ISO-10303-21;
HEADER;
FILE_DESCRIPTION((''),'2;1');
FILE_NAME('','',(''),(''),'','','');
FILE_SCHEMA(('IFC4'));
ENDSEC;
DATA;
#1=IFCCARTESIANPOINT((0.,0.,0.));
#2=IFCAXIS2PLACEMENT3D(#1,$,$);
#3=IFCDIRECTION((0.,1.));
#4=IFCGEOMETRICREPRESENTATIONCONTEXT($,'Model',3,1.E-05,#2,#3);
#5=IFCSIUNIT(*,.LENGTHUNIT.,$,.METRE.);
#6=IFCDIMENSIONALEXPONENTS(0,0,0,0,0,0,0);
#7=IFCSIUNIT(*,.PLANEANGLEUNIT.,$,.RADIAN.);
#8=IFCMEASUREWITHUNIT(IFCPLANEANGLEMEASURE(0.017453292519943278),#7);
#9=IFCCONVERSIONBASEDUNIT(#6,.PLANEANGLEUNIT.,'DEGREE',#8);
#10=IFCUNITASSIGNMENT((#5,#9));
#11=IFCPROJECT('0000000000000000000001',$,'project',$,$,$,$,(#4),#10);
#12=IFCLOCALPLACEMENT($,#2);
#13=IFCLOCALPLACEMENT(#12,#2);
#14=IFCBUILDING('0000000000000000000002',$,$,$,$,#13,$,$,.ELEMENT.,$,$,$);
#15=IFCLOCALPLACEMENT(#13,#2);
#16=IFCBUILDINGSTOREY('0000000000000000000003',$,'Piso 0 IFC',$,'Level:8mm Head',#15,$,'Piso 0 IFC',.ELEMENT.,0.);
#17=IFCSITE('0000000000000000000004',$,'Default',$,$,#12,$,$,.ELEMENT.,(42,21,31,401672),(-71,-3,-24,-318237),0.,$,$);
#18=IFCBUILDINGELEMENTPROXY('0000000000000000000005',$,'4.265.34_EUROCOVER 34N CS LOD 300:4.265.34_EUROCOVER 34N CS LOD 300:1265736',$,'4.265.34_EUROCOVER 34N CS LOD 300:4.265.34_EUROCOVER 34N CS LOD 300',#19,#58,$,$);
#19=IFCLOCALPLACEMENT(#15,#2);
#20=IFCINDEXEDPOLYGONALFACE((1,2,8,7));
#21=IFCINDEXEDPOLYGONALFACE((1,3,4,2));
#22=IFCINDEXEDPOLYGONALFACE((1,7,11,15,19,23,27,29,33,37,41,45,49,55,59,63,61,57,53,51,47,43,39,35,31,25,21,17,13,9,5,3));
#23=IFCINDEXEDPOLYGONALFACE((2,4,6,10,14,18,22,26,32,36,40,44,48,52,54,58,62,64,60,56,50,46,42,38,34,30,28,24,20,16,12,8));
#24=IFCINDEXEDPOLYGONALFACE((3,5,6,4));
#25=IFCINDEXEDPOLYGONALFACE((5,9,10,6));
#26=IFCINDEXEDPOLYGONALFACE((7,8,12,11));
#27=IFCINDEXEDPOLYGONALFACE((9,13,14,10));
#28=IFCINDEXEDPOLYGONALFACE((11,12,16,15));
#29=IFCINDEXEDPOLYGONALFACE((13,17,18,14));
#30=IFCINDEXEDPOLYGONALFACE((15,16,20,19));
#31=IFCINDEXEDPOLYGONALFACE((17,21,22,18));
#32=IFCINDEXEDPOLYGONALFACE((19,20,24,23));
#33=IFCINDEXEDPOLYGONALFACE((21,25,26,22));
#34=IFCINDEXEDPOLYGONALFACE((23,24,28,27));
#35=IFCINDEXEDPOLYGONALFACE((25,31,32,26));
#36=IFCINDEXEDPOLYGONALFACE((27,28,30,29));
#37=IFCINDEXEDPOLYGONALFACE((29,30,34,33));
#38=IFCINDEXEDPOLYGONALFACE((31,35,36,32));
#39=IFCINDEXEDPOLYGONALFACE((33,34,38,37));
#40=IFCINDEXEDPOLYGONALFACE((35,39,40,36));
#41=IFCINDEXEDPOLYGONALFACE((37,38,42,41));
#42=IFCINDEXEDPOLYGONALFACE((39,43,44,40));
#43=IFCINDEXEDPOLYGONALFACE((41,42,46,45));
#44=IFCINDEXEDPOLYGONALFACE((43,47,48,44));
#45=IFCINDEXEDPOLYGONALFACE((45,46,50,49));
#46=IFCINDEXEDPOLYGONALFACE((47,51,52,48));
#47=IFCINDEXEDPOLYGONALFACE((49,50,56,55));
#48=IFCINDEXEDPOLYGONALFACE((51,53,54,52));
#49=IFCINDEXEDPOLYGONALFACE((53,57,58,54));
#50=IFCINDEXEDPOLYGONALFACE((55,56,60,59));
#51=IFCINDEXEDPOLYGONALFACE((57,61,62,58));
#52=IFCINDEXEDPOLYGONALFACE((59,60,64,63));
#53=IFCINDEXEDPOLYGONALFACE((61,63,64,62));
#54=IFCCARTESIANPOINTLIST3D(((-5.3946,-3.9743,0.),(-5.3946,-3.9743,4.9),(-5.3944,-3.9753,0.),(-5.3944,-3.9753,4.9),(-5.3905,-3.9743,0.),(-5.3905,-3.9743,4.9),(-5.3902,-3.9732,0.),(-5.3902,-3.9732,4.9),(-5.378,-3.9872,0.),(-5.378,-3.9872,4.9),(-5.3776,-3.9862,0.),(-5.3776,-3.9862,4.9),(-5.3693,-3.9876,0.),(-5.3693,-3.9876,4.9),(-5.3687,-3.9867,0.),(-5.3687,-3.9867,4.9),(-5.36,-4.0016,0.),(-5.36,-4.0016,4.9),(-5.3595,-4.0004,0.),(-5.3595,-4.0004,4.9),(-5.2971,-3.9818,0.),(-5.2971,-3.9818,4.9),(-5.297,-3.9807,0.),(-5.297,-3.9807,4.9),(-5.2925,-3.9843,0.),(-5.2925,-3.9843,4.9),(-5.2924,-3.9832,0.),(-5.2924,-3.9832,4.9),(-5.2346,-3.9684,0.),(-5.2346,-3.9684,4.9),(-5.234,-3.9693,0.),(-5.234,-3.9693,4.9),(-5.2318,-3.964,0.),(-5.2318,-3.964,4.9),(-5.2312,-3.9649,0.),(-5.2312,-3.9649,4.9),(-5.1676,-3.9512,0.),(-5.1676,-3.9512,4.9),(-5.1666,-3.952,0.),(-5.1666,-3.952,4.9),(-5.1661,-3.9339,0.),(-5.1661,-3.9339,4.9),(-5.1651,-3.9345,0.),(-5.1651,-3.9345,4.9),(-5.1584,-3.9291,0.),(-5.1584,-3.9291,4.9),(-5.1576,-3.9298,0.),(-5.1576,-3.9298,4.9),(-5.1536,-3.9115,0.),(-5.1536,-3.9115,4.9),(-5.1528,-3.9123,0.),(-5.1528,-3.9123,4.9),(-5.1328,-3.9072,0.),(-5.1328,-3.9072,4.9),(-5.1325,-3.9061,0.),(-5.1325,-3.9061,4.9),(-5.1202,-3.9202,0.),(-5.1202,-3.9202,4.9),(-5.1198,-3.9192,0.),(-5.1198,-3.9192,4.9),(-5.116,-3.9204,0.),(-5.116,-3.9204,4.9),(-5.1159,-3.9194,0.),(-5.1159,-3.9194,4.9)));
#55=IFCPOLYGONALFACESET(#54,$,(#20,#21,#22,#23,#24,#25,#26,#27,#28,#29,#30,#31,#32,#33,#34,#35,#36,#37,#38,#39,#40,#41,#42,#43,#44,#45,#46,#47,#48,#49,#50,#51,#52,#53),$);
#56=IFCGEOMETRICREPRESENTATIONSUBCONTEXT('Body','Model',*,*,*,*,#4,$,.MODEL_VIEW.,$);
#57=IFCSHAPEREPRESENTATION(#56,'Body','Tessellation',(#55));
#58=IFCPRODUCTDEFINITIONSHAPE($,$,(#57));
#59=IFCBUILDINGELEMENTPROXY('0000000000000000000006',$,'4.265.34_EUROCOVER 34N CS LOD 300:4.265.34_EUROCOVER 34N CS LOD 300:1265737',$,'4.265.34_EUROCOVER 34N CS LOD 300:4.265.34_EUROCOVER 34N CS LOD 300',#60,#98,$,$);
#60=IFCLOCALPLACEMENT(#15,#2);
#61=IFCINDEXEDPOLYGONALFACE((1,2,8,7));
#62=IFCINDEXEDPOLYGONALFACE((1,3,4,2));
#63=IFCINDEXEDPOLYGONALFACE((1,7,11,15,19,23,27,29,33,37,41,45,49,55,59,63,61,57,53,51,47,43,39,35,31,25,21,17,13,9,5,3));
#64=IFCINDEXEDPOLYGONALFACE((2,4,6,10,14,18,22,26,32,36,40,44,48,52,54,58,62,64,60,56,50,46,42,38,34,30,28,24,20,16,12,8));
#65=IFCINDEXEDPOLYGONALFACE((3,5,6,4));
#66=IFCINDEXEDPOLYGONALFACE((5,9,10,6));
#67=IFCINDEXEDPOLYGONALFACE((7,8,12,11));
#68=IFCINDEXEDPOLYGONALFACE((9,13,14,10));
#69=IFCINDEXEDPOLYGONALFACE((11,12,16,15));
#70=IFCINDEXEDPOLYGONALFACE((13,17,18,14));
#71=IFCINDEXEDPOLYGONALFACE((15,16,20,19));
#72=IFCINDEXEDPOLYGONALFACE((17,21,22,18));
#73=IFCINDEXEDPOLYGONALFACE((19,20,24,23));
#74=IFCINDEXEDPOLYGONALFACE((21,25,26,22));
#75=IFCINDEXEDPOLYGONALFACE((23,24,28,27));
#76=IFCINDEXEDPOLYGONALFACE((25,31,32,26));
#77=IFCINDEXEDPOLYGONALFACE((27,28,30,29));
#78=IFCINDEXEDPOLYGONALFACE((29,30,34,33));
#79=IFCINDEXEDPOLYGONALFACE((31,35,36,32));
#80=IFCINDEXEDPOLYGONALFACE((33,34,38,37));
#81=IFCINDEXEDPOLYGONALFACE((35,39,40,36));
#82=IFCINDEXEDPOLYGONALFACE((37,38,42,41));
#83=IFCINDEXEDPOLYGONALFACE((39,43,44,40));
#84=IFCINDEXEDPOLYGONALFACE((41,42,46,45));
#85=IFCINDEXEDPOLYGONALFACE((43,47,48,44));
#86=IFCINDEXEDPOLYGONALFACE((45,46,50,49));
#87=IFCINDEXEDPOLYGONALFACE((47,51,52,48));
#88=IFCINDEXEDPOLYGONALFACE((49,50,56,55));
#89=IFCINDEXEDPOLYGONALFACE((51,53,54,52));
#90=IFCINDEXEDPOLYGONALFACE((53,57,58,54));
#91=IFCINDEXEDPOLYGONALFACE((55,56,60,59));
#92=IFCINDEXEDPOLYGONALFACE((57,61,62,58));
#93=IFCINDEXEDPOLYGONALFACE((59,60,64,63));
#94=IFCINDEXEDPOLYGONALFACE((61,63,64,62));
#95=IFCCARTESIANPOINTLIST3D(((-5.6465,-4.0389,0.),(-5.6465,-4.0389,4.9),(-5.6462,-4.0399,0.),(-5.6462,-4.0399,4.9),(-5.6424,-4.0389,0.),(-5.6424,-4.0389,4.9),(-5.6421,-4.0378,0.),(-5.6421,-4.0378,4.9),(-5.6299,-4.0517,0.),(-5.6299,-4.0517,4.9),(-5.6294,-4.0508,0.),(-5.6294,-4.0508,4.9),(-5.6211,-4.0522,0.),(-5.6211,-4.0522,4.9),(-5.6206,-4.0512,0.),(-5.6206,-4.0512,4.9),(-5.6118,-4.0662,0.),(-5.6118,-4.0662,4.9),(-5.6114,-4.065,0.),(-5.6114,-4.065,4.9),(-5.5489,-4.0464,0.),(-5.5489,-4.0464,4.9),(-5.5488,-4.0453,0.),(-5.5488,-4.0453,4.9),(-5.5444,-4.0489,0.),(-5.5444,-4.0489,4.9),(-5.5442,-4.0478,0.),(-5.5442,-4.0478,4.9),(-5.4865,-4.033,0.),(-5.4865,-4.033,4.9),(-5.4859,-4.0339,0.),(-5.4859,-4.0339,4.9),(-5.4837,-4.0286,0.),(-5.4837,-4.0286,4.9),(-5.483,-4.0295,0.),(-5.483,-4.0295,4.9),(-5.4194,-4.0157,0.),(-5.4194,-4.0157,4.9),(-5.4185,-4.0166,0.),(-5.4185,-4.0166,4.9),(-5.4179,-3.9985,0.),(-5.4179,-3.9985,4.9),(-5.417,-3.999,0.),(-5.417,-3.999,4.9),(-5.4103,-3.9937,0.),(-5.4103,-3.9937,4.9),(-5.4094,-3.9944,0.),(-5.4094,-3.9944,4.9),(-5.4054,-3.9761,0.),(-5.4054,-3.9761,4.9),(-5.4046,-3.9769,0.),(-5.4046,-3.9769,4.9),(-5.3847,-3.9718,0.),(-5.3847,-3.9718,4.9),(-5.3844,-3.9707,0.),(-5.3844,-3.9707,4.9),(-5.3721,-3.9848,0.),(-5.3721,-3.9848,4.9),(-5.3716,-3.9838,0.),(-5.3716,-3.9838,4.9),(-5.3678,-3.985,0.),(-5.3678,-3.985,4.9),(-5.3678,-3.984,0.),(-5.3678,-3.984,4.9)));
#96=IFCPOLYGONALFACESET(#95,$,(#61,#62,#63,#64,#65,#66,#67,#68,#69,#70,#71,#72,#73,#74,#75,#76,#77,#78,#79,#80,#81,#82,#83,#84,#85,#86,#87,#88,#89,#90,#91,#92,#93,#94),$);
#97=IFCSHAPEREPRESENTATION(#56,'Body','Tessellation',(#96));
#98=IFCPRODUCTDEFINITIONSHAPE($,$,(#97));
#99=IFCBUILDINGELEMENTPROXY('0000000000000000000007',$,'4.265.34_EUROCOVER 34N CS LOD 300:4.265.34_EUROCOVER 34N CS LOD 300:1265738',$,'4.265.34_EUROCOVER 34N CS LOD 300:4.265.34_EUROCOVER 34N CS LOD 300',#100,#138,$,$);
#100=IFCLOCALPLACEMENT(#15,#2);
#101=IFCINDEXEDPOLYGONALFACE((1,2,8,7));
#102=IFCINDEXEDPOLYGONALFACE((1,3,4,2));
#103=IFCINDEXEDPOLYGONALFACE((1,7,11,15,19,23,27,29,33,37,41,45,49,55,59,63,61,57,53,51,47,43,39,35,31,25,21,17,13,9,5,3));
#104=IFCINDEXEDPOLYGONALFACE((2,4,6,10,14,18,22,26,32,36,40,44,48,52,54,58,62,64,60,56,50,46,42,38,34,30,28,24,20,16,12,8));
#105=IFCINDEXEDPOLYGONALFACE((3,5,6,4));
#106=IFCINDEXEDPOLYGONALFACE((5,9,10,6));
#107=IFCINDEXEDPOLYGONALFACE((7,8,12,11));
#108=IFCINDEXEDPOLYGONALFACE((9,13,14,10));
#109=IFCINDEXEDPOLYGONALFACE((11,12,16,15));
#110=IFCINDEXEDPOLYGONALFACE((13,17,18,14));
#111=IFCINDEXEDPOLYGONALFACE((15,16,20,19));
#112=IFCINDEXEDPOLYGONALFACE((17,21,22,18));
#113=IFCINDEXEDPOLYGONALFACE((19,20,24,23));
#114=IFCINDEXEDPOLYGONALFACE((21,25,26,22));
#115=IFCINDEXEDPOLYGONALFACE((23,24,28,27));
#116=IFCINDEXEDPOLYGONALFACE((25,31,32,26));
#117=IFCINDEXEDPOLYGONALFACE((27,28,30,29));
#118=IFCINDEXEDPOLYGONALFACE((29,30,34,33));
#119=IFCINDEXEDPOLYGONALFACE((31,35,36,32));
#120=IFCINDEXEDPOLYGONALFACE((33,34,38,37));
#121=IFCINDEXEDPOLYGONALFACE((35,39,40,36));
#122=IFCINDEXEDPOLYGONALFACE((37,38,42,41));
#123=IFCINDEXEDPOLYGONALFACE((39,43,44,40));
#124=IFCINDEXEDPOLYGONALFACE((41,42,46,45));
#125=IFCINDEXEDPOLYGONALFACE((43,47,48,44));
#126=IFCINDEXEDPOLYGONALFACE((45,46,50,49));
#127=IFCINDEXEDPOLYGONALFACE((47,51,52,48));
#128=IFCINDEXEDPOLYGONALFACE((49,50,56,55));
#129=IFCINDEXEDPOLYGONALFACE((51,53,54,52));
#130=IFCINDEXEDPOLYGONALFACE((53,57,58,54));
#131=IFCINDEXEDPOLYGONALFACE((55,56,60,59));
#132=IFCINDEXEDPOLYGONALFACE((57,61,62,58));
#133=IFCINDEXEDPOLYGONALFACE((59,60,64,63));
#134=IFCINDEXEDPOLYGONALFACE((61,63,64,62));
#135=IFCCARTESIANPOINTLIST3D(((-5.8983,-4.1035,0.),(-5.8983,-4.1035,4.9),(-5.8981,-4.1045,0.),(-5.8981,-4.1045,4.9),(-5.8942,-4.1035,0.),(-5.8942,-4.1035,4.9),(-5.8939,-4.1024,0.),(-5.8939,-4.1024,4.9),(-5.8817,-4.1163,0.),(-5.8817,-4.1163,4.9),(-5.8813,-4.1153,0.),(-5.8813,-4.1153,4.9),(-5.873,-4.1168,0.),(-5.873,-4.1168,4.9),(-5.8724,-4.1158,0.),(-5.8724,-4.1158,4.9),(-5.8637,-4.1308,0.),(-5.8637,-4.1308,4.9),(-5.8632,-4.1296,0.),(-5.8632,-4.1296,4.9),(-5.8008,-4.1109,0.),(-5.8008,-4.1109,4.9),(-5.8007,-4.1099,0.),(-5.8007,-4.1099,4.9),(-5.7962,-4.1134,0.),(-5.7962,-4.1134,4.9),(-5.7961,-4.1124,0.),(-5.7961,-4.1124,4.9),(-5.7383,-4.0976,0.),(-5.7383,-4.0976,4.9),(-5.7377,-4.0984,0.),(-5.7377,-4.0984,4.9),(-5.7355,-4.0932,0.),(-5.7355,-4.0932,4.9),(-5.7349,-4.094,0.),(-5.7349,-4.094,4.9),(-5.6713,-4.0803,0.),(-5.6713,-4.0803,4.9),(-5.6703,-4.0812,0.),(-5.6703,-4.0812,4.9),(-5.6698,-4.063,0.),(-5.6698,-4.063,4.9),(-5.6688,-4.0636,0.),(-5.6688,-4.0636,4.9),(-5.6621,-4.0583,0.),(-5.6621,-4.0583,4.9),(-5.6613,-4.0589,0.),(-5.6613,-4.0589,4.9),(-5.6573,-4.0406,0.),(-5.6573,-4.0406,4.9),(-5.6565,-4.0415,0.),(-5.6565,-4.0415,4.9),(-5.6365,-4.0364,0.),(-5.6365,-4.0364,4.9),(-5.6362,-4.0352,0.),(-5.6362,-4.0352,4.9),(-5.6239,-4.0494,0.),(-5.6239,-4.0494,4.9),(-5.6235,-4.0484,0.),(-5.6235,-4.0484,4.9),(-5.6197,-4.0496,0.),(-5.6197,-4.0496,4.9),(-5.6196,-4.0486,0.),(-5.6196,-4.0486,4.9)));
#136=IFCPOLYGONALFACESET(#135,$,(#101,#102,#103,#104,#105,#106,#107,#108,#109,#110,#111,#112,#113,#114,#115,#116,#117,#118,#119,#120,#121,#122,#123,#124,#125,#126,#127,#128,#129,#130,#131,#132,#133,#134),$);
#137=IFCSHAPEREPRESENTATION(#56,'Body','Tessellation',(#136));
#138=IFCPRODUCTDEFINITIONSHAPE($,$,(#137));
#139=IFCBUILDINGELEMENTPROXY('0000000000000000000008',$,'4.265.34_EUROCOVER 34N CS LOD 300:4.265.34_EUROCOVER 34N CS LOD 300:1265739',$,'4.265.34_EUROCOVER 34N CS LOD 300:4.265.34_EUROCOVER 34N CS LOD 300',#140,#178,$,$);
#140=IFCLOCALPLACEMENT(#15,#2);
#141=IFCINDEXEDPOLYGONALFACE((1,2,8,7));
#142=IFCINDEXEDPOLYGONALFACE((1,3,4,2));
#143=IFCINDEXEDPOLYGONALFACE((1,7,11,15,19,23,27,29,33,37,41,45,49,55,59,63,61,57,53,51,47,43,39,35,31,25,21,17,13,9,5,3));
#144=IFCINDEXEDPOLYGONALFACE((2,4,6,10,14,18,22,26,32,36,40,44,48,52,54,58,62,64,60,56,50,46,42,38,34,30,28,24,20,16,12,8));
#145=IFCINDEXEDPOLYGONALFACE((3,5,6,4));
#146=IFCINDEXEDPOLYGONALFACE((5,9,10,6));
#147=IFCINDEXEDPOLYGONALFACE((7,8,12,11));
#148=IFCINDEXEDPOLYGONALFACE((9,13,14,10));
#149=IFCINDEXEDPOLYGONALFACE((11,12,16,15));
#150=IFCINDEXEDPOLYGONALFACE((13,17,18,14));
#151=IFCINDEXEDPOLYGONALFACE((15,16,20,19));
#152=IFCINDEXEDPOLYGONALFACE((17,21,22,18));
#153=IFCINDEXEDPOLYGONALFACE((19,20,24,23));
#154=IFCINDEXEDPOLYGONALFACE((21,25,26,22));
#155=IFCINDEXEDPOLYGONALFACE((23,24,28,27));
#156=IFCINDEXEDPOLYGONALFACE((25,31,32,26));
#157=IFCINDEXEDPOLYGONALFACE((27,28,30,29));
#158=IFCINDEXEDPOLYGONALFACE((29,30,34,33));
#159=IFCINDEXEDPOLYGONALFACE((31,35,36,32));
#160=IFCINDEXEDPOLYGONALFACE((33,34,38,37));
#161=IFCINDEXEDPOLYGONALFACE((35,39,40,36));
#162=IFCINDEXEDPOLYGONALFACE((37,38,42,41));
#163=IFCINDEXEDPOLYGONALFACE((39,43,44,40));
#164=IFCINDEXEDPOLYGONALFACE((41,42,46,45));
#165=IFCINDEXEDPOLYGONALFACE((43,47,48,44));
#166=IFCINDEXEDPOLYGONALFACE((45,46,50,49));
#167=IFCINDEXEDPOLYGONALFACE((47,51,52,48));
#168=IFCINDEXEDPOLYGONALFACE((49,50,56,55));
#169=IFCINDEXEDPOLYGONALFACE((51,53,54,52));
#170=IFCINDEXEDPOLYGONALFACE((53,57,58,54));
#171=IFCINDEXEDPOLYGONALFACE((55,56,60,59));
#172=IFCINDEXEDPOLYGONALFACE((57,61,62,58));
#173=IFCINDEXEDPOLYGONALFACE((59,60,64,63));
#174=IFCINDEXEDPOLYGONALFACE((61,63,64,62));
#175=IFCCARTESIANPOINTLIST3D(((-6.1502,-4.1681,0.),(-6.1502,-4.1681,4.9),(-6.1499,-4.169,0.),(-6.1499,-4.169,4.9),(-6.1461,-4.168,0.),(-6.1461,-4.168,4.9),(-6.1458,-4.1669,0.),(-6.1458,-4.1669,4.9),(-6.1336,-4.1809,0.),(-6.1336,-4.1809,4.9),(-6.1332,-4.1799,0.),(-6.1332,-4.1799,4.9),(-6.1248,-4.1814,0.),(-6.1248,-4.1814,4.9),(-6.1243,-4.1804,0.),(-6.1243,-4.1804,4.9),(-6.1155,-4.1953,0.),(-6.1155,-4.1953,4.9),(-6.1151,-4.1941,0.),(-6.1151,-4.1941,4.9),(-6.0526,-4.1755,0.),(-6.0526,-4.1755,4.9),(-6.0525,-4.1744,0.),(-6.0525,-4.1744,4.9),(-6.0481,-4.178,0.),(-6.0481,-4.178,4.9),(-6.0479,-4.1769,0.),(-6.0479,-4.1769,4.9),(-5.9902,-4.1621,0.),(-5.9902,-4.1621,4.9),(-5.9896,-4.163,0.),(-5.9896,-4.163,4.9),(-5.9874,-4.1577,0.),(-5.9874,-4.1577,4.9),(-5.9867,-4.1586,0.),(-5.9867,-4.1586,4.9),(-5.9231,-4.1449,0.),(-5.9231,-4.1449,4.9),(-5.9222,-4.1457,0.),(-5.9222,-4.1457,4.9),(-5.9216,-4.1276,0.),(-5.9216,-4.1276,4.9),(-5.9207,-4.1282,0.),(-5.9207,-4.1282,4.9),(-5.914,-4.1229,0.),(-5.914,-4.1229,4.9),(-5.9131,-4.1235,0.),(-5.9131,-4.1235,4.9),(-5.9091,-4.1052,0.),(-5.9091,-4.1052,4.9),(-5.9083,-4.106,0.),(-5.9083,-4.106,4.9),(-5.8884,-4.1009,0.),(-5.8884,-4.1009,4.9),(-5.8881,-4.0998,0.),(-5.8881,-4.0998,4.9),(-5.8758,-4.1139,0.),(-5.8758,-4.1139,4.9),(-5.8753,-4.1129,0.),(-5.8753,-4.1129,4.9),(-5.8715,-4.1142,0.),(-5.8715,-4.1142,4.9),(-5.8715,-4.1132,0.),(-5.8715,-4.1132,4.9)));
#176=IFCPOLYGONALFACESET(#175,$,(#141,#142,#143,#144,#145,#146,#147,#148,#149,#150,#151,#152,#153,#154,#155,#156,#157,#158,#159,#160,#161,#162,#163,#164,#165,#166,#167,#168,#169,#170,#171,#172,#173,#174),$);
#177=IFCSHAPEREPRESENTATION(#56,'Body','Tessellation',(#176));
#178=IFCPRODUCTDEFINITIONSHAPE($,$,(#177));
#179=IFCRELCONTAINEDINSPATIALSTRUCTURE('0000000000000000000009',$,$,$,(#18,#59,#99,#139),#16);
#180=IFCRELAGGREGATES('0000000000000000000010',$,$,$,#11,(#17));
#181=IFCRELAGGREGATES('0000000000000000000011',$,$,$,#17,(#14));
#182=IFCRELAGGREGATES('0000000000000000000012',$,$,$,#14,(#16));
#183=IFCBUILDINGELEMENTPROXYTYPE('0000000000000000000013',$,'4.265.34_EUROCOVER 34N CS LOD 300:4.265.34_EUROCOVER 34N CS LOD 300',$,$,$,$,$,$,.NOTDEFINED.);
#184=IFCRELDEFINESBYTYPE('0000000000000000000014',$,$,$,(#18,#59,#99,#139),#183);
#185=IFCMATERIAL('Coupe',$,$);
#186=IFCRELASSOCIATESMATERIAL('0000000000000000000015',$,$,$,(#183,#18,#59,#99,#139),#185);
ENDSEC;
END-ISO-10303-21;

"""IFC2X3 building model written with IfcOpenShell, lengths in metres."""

from ifc_helpers import new_model, entity, si_unit, converted_unit, direction, frame, origin, place, context, subcontext, project, spatial, polyline, outline, extrude, source, transform, mapped, material, type_object, type_shapes, element, save


model = new_model("IFC2X3")

# Units and contexts
model_context = context("Model", 3, precision=1e-05, world=origin(), true_north=direction((0.0, 1.0)))
body_context = subcontext(model_context, "Body", "Model", "MODEL_VIEW")
ifc_project = project(units=[si_unit("LENGTHUNIT", "METRE"), converted_unit("PLANEANGLEUNIT", "DEGREE", entity("IfcPlaneAngleMeasure", 0.017453292519943278), si_unit("PLANEANGLEUNIT", "RADIAN"), dimensions=[0, 0, 0, 0, 0, 0, 0])], contexts=[model_context])

# Site, building, storey
site_placement = place(None, origin())
site = spatial("IfcSite", under=ifc_project, at=site_placement, Name="Default", CompositionType="ELEMENT", RefLatitude=(42, 21, 31, 401672), RefLongitude=(-71, -3, -24, -318237), RefElevation=0.0)
building_placement = place(site_placement, origin())
building = spatial("IfcBuilding", under=site, at=building_placement, CompositionType="ELEMENT")
storey_placement = place(building_placement, origin())
storey = spatial("IfcBuildingStorey", under=building, at=storey_placement, Name="Piso 0 IFC", ObjectType="Level:8mm Head", LongName="Piso 0 IFC", CompositionType="ELEMENT", Elevation=0.0)

# Building element proxies
ifc_material_1 = material(Name="Coupe")
building_element_proxy_type = type_object("IfcBuildingElementProxyType", Name="4.265.34_EUROCOVER 34N CS LOD 300:4.265.34_EUROCOVER 34N CS LOD 300", PredefinedType="NOTDEFINED", material=ifc_material_1)
shared_shape_1 = source(origin(), body_context, "Body", "SweptSolid", [
    extrude(outline(polyline([(0.0449, 0.1162), (0.063, 0.1162), (0.0661, 0.1191), (0.0654, 0.1198), (0.0626, 0.1172), (0.0443, 0.1172), (0.0335, 0.0983), (0.0428, 0.0826), (0.0409, 0.0738), (0.0522, 0.0606), (0.0167, 0.0056), (0.0179, 0.0005), (-0.0117, -0.0512), (-0.0167, -0.0528), (-0.0462, -0.1114), (-0.0624, -0.1084), (-0.069, -0.1145), (-0.0871, -0.1145), (-0.0893, -0.1184), (-0.0885, -0.1189), (-0.0865, -0.1155), (-0.0686, -0.1155), (-0.0621, -0.1095), (-0.0456, -0.1125), (-0.016, -0.0536), (-0.0111, -0.0521), (0.0189, 0.0004), (0.0177, 0.0054), (0.0535, 0.0607), (0.0419, 0.074), (0.0438, 0.0827), (0.0347, 0.0983), (0.0449, 0.1162)])), frame((-0.0171, -0.0163, 0.0), z_axis=(0.0, 0.0, 1.0), x_axis=(-0.496574, 0.867994, 0.0)), (0.0, 0.0, 1.0), 4.9),
])
type_shapes(building_element_proxy_type, [shared_shape_1])
for number, where, z_axis, x_axis, name in (
    (1, (-5.26, -3.976, 0.0), (0.0, 0.0, 1.0), (-0.968666, -0.248367, 0.0), "4.265.34_EUROCOVER 34N CS LOD 300:4.265.34_EUROCOVER 34N CS LOD 300:1265736"),
    (2, (-5.5119, -4.0406, 0.0), (0.0, 0.0, 1.0), (-0.968666, -0.248367, 0.0), "4.265.34_EUROCOVER 34N CS LOD 300:4.265.34_EUROCOVER 34N CS LOD 300:1265737"),
    (3, (-5.7637, -4.1051, 0.0), (0.0, 0.0, 1.0), (-0.968666, -0.248367, 0.0), "4.265.34_EUROCOVER 34N CS LOD 300:4.265.34_EUROCOVER 34N CS LOD 300:1265738"),
    (4, (-6.0156, -4.1697, 0.0), (0.0, 0.0, 1.0), (-0.968666, -0.248367, 0.0), "4.265.34_EUROCOVER 34N CS LOD 300:4.265.34_EUROCOVER 34N CS LOD 300:1265739"),
):
    element("IfcBuildingElementProxy", number, at=place(storey_placement, frame(where, z_axis=z_axis, x_axis=x_axis)), inside=storey, type_object=building_element_proxy_type, material=ifc_material_1, Name=name, ObjectType="4.265.34_EUROCOVER 34N CS LOD 300:4.265.34_EUROCOVER 34N CS LOD 300", context=body_context, shape_type="MappedRepresentation", body=[
        mapped(shared_shape_1, transform((0.0, 0.0, 0.0), scale=1.0)),
    ])

save(model, "model.ifc")
